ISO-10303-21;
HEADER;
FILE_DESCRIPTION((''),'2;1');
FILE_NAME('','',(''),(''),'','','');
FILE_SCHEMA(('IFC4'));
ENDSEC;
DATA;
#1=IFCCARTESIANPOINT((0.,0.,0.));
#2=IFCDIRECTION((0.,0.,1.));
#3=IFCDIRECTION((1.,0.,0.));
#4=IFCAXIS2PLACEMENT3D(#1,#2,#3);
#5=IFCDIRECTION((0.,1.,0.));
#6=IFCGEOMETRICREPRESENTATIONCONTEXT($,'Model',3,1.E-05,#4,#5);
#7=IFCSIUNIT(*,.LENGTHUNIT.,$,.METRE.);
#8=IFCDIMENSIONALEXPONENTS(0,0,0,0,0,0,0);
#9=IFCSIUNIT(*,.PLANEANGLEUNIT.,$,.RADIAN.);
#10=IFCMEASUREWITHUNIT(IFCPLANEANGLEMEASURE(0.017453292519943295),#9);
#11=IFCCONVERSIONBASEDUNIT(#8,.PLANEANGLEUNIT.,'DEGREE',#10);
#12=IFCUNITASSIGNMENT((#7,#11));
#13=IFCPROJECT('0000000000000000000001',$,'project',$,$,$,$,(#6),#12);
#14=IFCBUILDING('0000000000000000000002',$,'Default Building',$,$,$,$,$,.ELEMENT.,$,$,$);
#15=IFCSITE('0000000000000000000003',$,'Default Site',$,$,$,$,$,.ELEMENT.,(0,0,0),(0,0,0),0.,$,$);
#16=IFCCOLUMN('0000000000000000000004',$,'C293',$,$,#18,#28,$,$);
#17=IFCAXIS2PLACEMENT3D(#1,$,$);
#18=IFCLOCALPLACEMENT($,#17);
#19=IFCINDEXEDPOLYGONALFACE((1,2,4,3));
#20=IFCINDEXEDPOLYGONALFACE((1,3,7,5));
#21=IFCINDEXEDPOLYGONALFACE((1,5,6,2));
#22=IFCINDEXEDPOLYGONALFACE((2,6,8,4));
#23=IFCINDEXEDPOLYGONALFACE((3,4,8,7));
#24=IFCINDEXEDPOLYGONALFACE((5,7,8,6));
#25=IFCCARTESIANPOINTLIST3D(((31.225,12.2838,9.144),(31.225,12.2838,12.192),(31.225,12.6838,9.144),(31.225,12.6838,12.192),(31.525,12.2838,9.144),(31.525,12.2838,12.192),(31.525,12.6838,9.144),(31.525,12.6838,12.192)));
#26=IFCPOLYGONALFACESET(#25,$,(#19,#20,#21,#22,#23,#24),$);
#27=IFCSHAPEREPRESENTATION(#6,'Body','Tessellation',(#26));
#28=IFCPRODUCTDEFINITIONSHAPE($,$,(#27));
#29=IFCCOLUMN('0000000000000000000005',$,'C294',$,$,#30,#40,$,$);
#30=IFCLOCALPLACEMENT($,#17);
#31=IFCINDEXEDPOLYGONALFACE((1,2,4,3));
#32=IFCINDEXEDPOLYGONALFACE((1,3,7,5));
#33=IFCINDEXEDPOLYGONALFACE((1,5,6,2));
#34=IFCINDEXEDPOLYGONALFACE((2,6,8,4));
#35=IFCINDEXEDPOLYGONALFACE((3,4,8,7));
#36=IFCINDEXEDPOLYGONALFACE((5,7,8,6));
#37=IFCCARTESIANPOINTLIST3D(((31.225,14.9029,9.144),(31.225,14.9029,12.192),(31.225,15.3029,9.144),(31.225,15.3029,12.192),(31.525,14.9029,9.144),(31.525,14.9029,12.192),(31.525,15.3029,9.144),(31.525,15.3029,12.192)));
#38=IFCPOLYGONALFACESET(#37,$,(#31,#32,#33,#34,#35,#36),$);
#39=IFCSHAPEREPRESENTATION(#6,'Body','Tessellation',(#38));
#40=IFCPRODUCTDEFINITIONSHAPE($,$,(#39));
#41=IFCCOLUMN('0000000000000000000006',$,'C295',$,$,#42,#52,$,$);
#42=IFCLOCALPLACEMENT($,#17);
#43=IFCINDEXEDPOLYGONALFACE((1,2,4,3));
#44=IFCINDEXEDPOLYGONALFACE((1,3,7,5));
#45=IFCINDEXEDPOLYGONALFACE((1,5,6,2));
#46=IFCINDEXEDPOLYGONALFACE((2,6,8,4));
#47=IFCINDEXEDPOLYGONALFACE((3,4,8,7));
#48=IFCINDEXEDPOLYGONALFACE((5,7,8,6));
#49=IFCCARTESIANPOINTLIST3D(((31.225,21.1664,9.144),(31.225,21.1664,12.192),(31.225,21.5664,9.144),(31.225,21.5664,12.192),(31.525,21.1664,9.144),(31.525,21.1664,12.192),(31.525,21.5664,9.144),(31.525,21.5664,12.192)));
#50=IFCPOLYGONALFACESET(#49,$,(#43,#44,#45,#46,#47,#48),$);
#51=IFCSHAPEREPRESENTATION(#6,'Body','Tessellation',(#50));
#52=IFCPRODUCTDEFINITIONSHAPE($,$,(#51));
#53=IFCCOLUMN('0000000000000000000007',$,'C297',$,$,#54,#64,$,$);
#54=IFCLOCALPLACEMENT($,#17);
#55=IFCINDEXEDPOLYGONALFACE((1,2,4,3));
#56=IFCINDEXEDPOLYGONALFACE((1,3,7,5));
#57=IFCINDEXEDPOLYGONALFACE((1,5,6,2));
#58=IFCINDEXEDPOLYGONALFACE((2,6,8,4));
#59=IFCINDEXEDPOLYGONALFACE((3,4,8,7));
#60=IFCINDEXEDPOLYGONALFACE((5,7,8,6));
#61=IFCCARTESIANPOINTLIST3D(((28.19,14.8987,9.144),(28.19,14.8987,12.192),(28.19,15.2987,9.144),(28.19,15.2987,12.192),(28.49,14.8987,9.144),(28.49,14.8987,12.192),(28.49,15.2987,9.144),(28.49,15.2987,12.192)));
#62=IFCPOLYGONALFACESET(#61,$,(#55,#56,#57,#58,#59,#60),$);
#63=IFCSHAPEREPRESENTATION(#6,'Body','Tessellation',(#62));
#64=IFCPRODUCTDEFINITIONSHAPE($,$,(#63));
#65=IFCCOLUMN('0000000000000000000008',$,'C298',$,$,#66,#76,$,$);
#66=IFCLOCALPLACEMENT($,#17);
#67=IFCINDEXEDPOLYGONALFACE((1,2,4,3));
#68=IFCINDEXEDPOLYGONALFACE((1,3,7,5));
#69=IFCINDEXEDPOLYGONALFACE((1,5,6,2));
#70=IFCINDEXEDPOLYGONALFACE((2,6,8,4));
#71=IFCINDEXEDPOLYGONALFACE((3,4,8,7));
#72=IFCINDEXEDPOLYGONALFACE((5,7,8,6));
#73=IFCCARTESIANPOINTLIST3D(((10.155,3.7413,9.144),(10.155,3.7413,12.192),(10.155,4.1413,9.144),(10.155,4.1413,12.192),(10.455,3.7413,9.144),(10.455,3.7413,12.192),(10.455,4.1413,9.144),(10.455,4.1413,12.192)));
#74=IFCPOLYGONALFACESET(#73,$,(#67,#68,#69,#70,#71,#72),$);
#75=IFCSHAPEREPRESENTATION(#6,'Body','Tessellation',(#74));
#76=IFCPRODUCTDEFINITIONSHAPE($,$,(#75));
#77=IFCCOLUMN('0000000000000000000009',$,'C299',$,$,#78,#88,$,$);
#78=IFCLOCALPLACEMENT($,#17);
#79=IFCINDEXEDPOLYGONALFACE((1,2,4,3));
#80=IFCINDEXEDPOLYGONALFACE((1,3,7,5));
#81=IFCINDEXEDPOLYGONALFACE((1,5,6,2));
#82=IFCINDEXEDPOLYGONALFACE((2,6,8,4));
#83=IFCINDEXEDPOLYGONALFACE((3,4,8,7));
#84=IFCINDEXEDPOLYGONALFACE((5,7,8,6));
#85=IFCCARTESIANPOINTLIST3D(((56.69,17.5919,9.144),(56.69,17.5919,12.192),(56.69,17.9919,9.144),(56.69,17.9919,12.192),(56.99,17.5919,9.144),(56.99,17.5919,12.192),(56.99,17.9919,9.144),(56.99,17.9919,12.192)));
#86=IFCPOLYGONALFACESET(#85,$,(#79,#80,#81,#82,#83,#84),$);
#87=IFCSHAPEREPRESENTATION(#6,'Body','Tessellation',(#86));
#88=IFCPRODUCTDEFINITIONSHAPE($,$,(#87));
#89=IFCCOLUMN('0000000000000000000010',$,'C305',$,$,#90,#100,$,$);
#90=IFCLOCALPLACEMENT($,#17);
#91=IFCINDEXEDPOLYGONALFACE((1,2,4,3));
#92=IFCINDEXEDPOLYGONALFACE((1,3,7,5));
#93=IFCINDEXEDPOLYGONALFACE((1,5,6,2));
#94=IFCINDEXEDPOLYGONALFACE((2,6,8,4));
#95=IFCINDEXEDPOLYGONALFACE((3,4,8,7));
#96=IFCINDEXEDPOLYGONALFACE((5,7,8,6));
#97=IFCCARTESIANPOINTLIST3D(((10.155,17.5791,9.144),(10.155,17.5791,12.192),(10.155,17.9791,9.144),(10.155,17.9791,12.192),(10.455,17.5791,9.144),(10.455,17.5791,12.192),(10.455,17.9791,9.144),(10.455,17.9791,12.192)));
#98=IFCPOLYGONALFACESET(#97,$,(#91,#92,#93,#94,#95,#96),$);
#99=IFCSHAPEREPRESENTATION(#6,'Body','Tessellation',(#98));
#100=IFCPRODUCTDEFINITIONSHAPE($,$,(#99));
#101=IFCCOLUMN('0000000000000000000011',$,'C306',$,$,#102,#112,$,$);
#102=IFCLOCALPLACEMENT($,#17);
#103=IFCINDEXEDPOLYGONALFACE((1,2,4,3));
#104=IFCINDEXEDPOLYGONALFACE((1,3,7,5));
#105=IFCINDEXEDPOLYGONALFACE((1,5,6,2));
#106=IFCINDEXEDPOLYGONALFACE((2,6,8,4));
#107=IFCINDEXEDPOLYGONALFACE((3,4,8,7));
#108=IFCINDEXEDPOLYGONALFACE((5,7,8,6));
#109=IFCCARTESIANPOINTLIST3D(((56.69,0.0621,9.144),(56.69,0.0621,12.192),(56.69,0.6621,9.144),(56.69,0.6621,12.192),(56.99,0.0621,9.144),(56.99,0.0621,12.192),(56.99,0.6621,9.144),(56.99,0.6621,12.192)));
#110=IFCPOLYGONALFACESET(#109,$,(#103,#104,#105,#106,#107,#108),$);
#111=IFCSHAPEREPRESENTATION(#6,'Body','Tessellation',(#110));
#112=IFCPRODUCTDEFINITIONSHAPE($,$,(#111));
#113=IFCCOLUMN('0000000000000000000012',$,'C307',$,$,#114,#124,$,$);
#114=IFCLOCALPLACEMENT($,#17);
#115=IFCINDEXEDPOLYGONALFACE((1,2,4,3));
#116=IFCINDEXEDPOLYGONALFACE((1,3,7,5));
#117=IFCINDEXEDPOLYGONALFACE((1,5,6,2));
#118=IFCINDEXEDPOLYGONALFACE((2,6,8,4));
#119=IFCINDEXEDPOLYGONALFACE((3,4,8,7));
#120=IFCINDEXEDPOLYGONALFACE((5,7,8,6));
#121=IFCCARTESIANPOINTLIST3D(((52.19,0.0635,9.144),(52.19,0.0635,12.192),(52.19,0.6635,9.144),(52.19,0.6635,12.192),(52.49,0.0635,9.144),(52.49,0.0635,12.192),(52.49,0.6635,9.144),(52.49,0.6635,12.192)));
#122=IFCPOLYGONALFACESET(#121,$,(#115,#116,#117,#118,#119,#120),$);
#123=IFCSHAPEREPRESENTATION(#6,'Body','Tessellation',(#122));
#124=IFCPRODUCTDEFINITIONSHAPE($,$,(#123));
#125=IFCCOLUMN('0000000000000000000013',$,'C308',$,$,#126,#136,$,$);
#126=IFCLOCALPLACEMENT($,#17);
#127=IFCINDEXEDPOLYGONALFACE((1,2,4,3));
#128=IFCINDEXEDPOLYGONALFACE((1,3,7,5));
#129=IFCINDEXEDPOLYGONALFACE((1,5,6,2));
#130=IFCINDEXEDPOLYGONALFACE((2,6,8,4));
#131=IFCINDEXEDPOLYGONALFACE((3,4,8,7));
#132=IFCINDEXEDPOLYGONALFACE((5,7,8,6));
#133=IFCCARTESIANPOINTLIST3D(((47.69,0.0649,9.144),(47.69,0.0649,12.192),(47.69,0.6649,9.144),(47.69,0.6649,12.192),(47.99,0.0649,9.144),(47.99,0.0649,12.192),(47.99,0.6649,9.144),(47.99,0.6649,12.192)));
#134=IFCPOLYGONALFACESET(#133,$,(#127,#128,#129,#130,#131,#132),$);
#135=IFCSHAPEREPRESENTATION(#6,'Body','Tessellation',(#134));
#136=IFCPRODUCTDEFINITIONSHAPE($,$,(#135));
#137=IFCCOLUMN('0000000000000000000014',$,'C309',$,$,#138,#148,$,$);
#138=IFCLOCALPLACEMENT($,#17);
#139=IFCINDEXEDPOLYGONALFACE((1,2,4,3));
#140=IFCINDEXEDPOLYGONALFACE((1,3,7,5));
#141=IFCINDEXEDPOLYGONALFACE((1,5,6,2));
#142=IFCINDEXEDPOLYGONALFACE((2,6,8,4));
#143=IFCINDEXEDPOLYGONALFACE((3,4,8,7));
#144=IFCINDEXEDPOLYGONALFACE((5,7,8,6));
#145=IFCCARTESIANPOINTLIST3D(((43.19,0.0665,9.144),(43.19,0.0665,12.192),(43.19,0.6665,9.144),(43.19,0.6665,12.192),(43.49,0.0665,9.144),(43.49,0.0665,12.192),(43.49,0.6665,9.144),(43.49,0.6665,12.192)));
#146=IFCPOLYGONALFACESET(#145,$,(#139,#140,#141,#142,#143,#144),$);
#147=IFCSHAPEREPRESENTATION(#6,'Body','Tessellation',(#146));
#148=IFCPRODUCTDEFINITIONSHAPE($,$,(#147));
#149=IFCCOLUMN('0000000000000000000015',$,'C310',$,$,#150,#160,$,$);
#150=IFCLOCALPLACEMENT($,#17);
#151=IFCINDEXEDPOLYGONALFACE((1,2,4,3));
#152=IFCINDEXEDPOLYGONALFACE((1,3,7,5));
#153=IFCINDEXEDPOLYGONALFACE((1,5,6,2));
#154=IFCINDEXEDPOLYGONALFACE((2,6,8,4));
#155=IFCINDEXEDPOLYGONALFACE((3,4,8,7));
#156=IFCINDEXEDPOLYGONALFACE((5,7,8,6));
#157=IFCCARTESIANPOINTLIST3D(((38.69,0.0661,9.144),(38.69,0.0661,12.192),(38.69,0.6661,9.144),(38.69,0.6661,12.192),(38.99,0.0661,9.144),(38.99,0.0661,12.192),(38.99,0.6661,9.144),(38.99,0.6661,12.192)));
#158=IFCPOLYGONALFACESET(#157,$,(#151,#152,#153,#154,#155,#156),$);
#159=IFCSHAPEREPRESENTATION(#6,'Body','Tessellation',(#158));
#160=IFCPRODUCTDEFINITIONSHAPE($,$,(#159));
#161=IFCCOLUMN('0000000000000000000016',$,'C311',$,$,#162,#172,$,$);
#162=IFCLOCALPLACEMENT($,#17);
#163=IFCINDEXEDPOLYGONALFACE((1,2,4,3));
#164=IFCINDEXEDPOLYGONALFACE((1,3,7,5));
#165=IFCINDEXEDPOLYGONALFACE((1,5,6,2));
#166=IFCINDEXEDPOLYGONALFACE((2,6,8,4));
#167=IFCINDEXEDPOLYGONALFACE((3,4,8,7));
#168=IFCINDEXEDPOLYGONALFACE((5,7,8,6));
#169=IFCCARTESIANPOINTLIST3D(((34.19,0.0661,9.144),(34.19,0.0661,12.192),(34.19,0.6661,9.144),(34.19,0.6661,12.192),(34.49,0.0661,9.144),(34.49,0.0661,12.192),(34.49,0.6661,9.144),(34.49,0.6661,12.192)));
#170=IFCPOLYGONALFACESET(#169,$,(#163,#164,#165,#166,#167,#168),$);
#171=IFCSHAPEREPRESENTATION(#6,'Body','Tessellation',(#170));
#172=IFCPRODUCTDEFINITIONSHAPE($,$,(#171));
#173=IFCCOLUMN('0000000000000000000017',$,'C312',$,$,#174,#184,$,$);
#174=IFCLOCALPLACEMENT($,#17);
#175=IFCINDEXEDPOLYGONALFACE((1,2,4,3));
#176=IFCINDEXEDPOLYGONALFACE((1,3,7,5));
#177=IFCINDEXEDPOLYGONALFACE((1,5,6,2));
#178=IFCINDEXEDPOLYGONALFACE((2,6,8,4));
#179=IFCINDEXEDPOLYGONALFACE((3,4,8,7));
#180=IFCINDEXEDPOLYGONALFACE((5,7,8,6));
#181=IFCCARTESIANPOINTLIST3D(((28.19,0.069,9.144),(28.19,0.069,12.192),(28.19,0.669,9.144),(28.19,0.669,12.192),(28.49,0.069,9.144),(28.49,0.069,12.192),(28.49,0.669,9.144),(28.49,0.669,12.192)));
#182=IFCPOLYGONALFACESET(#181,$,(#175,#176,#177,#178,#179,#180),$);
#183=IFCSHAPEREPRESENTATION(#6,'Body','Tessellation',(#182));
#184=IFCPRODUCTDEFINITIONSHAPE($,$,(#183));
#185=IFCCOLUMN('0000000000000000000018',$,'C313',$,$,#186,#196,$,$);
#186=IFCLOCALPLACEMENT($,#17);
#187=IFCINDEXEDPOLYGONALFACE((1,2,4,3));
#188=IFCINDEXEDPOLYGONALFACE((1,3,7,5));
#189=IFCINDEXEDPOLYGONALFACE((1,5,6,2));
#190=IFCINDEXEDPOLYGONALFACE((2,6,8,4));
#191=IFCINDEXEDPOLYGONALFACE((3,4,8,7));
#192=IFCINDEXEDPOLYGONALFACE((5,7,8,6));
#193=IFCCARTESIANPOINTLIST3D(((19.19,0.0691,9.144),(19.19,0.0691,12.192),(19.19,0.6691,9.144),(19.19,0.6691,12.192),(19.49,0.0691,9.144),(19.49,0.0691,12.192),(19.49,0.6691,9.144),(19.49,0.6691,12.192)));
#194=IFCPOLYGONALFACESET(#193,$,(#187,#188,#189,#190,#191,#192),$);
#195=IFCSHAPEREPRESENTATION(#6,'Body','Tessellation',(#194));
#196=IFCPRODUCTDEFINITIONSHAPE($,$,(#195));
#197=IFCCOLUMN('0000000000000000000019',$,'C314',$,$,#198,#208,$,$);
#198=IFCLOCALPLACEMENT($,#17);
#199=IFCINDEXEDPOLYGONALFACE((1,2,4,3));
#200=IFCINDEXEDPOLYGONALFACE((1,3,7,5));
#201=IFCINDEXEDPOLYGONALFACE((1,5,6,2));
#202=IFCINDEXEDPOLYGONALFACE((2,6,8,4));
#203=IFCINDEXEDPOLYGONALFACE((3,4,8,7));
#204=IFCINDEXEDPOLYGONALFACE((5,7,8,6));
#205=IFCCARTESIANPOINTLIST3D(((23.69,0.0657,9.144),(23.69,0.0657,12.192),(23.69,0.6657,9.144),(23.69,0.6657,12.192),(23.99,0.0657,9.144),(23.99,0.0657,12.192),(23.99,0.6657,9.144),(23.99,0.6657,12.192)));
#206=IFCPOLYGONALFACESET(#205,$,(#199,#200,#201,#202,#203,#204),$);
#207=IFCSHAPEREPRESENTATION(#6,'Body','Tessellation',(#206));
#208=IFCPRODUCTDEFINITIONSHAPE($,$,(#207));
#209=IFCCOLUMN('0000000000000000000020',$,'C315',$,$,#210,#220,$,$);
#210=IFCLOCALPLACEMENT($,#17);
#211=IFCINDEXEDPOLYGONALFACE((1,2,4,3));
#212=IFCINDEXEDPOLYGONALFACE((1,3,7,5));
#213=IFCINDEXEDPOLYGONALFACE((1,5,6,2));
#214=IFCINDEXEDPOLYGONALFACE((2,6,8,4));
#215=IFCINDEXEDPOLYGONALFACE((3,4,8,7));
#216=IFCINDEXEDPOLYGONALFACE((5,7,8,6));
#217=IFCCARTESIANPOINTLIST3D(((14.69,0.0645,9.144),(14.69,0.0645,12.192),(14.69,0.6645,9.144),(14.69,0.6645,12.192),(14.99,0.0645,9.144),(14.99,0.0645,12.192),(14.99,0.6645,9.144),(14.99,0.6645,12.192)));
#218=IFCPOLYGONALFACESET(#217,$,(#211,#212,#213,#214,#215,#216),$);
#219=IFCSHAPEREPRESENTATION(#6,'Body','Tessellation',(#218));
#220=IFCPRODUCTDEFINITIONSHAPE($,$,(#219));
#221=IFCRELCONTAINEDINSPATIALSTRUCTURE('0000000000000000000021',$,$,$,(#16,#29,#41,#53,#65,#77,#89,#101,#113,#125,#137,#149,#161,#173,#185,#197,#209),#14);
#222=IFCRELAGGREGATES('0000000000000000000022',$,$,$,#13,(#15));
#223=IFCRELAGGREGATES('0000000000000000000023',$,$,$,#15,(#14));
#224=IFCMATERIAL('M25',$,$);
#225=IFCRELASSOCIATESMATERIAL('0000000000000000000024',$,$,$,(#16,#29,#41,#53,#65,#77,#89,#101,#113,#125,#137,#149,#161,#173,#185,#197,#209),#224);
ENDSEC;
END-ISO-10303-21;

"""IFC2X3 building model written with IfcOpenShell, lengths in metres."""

from ifc_helpers import new_model, entity, si_unit, converted_unit, direction, frame, frame_2d, origin_with_axes, place, context, project, spatial, rectangle, extrude, material, element, save


model = new_model("IFC2X3")

# Units and contexts
model_context = context("Model", 3, precision=1e-05, world=origin_with_axes(), true_north=direction((0.0, 1.0, 0.0)))
ifc_project = project(units=[si_unit("LENGTHUNIT", "METRE"), converted_unit("PLANEANGLEUNIT", "DEGREE", entity("IfcPlaneAngleMeasure", 0.017453292519943295), si_unit("PLANEANGLEUNIT", "RADIAN"), dimensions=[0, 0, 0, 0, 0, 0, 0])], contexts=[model_context])

# Site, building
site = spatial("IfcSite", under=ifc_project, Name="Default Site", CompositionType="ELEMENT", RefLatitude=(0, 0, 0), RefLongitude=(0, 0, 0), RefElevation=0.0)
building = spatial("IfcBuilding", under=site, Name="Default Building", CompositionType="ELEMENT")

# Columns
ifc_material = material(Name="M25")
placement = place(None, origin_with_axes())
element("IfcColumn", 1, at=placement, inside=building, material=ifc_material, Name="C293", context=model_context, shape_type="SweptSolid", body=[
    extrude(rectangle(XDim=0.3, YDim=0.4, at=frame_2d((0.0, 0.0), x_axis=(1.0, 0.0, 0.0))), frame((31.375, 12.4838, 9.144), z_axis=(0.0, 0.0, 1.0), x_axis=(1.0, 0.0, 0.0)), (0.0, 0.0, 1.0), 3.048),
])
element("IfcColumn", 2, at=placement, inside=building, material=ifc_material, Name="C294", context=model_context, shape_type="SweptSolid", body=[
    extrude(rectangle(XDim=0.3, YDim=0.4, at=frame_2d((0.0, 0.0), x_axis=(1.0, 0.0, 0.0))), frame((31.375, 15.1029, 9.144), z_axis=(0.0, 0.0, 1.0), x_axis=(1.0, 0.0, 0.0)), (0.0, 0.0, 1.0), 3.048),
])
element("IfcColumn", 3, at=placement, inside=building, material=ifc_material, Name="C295", context=model_context, shape_type="SweptSolid", body=[
    extrude(rectangle(XDim=0.3, YDim=0.4, at=frame_2d((0.0, 0.0), x_axis=(1.0, 0.0, 0.0))), frame((31.375, 21.3664, 9.144), z_axis=(0.0, 0.0, 1.0), x_axis=(1.0, 0.0, 0.0)), (0.0, 0.0, 1.0), 3.048),
])
element("IfcColumn", 4, at=placement, inside=building, material=ifc_material, Name="C297", context=model_context, shape_type="SweptSolid", body=[
    extrude(rectangle(XDim=0.3, YDim=0.4, at=frame_2d((0.0, 0.0), x_axis=(1.0, 0.0, 0.0))), frame((28.34, 15.0987, 9.144), z_axis=(0.0, 0.0, 1.0), x_axis=(1.0, 0.0, 0.0)), (0.0, 0.0, 1.0), 3.048),
])
element("IfcColumn", 5, at=placement, inside=building, material=ifc_material, Name="C298", context=model_context, shape_type="SweptSolid", body=[
    extrude(rectangle(XDim=0.3, YDim=0.4, at=frame_2d((0.0, 0.0), x_axis=(1.0, 0.0, 0.0))), frame((10.305, 3.9413, 9.144), z_axis=(0.0, 0.0, 1.0), x_axis=(1.0, 0.0, 0.0)), (0.0, 0.0, 1.0), 3.048),
])
element("IfcColumn", 6, at=placement, inside=building, material=ifc_material, Name="C299", context=model_context, shape_type="SweptSolid", body=[
    extrude(rectangle(XDim=0.3, YDim=0.4, at=frame_2d((0.0, 0.0), x_axis=(1.0, 0.0, 0.0))), frame((56.84, 17.7919, 9.144), z_axis=(0.0, 0.0, 1.0), x_axis=(1.0, 0.0, 0.0)), (0.0, 0.0, 1.0), 3.048),
])
element("IfcColumn", 7, at=placement, inside=building, material=ifc_material, Name="C305", context=model_context, shape_type="SweptSolid", body=[
    extrude(rectangle(XDim=0.3, YDim=0.4, at=frame_2d((0.0, 0.0), x_axis=(1.0, 0.0, 0.0))), frame((10.305, 17.7791, 9.144), z_axis=(0.0, 0.0, 1.0), x_axis=(1.0, 0.0, 0.0)), (0.0, 0.0, 1.0), 3.048),
])
element("IfcColumn", 8, at=placement, inside=building, material=ifc_material, Name="C306", context=model_context, shape_type="SweptSolid", body=[
    extrude(rectangle(XDim=0.3, YDim=0.6, at=frame_2d((0.0, 0.0), x_axis=(1.0, 0.0, 0.0))), frame((56.84, 0.3621, 9.144), z_axis=(0.0, 0.0, 1.0), x_axis=(1.0, 0.0, 0.0)), (0.0, 0.0, 1.0), 3.048),
])
element("IfcColumn", 9, at=placement, inside=building, material=ifc_material, Name="C307", context=model_context, shape_type="SweptSolid", body=[
    extrude(rectangle(XDim=0.3, YDim=0.6, at=frame_2d((0.0, 0.0), x_axis=(1.0, 0.0, 0.0))), frame((52.34, 0.3635, 9.144), z_axis=(0.0, 0.0, 1.0), x_axis=(1.0, 0.0, 0.0)), (0.0, 0.0, 1.0), 3.048),
])
element("IfcColumn", 10, at=placement, inside=building, material=ifc_material, Name="C308", context=model_context, shape_type="SweptSolid", body=[
    extrude(rectangle(XDim=0.3, YDim=0.6, at=frame_2d((0.0, 0.0), x_axis=(1.0, 0.0, 0.0))), frame((47.84, 0.3649, 9.144), z_axis=(0.0, 0.0, 1.0), x_axis=(1.0, 0.0, 0.0)), (0.0, 0.0, 1.0), 3.048),
])
element("IfcColumn", 11, at=placement, inside=building, material=ifc_material, Name="C309", context=model_context, shape_type="SweptSolid", body=[
    extrude(rectangle(XDim=0.3, YDim=0.6, at=frame_2d((0.0, 0.0), x_axis=(1.0, 0.0, 0.0))), frame((43.34, 0.3665, 9.144), z_axis=(0.0, 0.0, 1.0), x_axis=(1.0, 0.0, 0.0)), (0.0, 0.0, 1.0), 3.048),
])
element("IfcColumn", 12, at=placement, inside=building, material=ifc_material, Name="C310", context=model_context, shape_type="SweptSolid", body=[
    extrude(rectangle(XDim=0.3, YDim=0.6, at=frame_2d((0.0, 0.0), x_axis=(1.0, 0.0, 0.0))), frame((38.84, 0.3661, 9.144), z_axis=(0.0, 0.0, 1.0), x_axis=(1.0, 0.0, 0.0)), (0.0, 0.0, 1.0), 3.048),
])
element("IfcColumn", 13, at=placement, inside=building, material=ifc_material, Name="C311", context=model_context, shape_type="SweptSolid", body=[
    extrude(rectangle(XDim=0.3, YDim=0.6, at=frame_2d((0.0, 0.0), x_axis=(1.0, 0.0, 0.0))), frame((34.34, 0.3661, 9.144), z_axis=(0.0, 0.0, 1.0), x_axis=(1.0, 0.0, 0.0)), (0.0, 0.0, 1.0), 3.048),
])
element("IfcColumn", 14, at=placement, inside=building, material=ifc_material, Name="C312", context=model_context, shape_type="SweptSolid", body=[
    extrude(rectangle(XDim=0.3, YDim=0.6, at=frame_2d((0.0, 0.0), x_axis=(1.0, 0.0, 0.0))), frame((28.34, 0.369, 9.144), z_axis=(0.0, 0.0, 1.0), x_axis=(1.0, 0.0, 0.0)), (0.0, 0.0, 1.0), 3.048),
])
element("IfcColumn", 15, at=placement, inside=building, material=ifc_material, Name="C313", context=model_context, shape_type="SweptSolid", body=[
    extrude(rectangle(XDim=0.3, YDim=0.6, at=frame_2d((0.0, 0.0), x_axis=(1.0, 0.0, 0.0))), frame((19.34, 0.3691, 9.144), z_axis=(0.0, 0.0, 1.0), x_axis=(1.0, 0.0, 0.0)), (0.0, 0.0, 1.0), 3.048),
])
element("IfcColumn", 16, at=placement, inside=building, material=ifc_material, Name="C314", context=model_context, shape_type="SweptSolid", body=[
    extrude(rectangle(XDim=0.3, YDim=0.6, at=frame_2d((0.0, 0.0), x_axis=(1.0, 0.0, 0.0))), frame((23.84, 0.3657, 9.144), z_axis=(0.0, 0.0, 1.0), x_axis=(1.0, 0.0, 0.0)), (0.0, 0.0, 1.0), 3.048),
])
element("IfcColumn", 17, at=placement, inside=building, material=ifc_material, Name="C315", context=model_context, shape_type="SweptSolid", body=[
    extrude(rectangle(XDim=0.3, YDim=0.6, at=frame_2d((0.0, 0.0), x_axis=(1.0, 0.0, 0.0))), frame((14.84, 0.3645, 9.144), z_axis=(0.0, 0.0, 1.0), x_axis=(1.0, 0.0, 0.0)), (0.0, 0.0, 1.0), 3.048),
])

save(model, "model.ifc")
